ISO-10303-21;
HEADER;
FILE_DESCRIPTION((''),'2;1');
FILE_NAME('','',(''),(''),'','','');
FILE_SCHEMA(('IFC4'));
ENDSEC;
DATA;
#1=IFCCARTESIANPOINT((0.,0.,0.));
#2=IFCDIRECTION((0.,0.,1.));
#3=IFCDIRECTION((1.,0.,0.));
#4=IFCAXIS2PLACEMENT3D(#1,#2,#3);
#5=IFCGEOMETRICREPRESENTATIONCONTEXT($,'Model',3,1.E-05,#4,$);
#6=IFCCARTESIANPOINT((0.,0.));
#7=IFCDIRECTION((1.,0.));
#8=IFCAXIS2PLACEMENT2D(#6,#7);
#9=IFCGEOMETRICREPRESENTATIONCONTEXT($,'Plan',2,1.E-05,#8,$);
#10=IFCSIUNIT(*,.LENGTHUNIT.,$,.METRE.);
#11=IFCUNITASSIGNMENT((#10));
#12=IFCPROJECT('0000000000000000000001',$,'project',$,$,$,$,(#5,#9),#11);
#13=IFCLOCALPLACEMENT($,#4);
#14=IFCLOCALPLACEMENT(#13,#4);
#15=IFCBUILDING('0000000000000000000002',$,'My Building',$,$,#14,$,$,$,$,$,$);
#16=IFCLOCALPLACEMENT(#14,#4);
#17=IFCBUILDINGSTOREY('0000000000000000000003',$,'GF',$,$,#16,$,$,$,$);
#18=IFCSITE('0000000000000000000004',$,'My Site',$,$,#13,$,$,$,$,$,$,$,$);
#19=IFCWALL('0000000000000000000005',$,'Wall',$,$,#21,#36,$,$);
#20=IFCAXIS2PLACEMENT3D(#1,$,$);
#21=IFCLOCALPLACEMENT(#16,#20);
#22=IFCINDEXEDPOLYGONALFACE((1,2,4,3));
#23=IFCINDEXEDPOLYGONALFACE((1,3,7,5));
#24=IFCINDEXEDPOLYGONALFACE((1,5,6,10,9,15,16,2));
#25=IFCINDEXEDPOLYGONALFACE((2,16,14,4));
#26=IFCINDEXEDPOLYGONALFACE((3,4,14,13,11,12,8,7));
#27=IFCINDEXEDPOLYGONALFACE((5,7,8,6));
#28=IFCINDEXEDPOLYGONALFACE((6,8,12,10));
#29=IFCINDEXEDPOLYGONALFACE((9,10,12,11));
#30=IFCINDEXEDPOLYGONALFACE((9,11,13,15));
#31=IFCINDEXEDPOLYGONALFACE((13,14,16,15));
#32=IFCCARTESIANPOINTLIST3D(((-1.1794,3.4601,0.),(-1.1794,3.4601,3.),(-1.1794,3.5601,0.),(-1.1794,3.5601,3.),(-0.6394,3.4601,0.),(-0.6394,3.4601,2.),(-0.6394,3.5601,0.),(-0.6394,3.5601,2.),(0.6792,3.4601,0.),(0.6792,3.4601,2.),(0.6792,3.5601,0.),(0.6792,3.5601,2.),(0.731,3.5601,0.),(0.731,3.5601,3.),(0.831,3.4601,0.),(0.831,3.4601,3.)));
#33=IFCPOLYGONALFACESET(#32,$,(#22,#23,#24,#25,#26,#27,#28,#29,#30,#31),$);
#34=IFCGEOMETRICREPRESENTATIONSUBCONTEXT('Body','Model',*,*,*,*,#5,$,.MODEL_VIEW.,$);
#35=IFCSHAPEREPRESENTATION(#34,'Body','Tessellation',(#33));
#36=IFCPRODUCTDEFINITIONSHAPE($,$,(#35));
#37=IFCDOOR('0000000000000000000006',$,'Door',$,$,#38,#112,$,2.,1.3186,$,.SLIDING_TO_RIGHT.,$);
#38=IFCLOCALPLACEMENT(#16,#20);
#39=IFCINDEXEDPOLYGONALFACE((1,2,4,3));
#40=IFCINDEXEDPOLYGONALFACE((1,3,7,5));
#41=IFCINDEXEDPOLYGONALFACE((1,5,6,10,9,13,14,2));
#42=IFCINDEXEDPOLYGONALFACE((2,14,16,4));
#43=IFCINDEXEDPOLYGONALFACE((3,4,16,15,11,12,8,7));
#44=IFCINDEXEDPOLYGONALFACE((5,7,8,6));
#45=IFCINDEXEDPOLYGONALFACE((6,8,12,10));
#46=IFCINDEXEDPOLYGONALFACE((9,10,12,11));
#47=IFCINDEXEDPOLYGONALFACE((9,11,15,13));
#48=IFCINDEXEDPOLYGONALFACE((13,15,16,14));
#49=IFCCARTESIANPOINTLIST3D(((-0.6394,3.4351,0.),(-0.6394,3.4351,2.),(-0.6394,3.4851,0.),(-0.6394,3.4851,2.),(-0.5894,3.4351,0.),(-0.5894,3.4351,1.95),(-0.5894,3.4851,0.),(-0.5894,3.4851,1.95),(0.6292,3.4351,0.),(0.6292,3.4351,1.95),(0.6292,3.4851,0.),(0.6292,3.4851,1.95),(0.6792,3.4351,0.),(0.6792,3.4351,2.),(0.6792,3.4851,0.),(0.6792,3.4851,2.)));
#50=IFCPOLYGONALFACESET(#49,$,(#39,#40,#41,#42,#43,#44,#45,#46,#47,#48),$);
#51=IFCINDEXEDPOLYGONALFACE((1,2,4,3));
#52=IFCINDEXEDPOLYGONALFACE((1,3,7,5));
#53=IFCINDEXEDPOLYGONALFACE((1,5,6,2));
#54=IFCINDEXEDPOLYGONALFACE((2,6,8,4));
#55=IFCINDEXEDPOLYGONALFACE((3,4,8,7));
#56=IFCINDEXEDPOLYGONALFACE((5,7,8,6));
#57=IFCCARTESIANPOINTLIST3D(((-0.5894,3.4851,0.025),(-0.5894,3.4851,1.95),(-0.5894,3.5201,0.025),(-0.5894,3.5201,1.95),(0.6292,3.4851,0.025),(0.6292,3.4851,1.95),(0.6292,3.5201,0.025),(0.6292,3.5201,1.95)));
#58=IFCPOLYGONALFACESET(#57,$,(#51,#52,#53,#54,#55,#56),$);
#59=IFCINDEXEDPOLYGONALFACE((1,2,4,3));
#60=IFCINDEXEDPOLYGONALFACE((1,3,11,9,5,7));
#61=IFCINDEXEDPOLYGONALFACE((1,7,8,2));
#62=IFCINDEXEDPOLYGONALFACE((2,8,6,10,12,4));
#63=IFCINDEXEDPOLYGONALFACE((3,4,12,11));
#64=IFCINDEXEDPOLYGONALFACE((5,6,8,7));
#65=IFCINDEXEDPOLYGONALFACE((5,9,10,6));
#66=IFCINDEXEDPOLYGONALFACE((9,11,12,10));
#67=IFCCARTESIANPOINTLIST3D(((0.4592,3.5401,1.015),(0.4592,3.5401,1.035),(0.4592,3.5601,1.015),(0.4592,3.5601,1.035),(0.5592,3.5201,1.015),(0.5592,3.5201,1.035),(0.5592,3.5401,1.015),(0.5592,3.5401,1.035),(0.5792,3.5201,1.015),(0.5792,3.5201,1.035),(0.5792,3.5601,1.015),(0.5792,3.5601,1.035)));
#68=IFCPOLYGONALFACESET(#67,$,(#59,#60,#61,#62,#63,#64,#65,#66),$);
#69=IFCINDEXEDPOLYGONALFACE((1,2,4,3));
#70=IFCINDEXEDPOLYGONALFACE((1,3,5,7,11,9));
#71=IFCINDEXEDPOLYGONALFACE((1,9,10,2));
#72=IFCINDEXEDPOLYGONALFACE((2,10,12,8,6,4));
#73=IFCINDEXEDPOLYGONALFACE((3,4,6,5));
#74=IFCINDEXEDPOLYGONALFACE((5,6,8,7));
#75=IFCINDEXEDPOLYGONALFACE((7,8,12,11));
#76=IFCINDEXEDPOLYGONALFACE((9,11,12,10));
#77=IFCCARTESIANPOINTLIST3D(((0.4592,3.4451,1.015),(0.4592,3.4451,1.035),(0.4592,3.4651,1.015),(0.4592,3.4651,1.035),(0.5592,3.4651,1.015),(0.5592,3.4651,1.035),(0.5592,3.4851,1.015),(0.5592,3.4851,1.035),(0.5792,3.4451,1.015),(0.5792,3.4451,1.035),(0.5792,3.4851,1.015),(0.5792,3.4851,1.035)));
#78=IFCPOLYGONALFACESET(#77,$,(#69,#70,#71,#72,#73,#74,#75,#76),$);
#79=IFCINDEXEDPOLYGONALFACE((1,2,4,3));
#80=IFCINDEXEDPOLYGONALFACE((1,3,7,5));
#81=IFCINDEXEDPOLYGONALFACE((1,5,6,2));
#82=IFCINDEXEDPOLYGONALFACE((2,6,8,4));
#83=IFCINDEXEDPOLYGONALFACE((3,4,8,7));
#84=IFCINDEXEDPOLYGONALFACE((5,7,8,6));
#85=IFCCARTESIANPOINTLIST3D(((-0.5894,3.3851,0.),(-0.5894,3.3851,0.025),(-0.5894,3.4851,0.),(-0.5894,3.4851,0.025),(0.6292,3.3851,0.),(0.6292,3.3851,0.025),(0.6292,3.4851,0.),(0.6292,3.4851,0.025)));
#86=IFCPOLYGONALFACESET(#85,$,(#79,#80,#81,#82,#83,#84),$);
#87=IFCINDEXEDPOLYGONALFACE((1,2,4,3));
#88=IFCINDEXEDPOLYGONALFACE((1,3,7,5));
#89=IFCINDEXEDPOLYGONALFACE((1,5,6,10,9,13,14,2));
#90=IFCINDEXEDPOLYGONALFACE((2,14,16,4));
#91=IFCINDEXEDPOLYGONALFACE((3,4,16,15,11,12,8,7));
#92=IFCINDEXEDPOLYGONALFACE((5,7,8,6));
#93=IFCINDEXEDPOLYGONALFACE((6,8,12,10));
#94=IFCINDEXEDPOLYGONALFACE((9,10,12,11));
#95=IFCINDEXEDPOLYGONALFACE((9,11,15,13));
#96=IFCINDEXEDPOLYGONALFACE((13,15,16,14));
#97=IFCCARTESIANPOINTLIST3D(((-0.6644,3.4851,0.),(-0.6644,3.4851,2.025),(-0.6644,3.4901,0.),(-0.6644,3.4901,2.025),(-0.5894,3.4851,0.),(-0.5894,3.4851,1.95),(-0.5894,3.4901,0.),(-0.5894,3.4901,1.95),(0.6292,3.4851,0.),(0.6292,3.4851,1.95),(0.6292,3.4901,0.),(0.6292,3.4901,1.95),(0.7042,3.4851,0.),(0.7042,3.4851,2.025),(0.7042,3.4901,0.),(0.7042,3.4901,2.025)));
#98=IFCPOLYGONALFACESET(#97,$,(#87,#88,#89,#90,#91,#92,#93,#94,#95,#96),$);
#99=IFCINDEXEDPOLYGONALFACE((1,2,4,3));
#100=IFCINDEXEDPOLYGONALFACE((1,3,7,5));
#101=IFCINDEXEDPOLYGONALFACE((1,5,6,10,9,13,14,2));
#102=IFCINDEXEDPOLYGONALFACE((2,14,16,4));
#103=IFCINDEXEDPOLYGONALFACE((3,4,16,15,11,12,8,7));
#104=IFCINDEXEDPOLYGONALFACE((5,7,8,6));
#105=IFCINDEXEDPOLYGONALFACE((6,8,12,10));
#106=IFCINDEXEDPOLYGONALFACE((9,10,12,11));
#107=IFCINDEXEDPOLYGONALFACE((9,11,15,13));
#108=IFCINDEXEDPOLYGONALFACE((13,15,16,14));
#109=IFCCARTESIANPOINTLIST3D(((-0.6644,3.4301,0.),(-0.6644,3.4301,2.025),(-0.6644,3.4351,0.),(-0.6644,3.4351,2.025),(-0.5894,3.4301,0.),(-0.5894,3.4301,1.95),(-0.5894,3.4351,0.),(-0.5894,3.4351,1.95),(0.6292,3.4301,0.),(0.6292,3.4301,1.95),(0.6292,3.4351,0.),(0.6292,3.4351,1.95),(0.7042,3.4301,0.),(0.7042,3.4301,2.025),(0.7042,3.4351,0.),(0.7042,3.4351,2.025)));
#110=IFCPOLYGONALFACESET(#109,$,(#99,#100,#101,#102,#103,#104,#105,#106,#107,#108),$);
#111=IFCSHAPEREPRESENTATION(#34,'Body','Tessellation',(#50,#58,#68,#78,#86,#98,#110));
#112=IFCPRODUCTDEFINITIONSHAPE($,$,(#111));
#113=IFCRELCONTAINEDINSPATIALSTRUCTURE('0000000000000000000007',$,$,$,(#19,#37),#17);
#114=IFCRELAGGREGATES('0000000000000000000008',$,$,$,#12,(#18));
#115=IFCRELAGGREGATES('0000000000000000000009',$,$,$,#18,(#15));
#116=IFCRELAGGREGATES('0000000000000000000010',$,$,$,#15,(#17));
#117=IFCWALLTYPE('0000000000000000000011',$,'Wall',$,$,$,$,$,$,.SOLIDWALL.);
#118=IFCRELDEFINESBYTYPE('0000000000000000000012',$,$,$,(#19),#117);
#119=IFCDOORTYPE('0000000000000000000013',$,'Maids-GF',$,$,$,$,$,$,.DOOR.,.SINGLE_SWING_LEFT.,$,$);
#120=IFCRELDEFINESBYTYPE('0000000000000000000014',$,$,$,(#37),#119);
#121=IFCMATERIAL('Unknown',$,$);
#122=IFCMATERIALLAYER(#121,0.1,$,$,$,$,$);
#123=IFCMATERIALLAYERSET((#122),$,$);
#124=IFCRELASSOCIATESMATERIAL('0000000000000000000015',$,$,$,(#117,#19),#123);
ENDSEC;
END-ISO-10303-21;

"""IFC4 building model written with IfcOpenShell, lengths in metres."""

from ifc_helpers import new_model, entity, si_unit, frame, origin_with_axes, origin_2d_with_axis, place, context, subcontext, project, spatial, line, indexed_curve, outline, extrude, shape, source, transform, mapped, material, layer, layer_set, layer_usage, type_object, type_shapes, element, fill, save


model = new_model("IFC4")

# Units and contexts
model_context = context("Model", 3, precision=1e-05, world=origin_with_axes())
plan_context = context("Plan", 2, precision=1e-05, world=origin_2d_with_axis())
body_context_1 = subcontext(model_context, "Body", "Model", "MODEL_VIEW")
body_context_2 = subcontext(plan_context, "Body", "Plan", "PLAN_VIEW")
ifc_project = project(units=[si_unit("LENGTHUNIT", "METRE")], contexts=[model_context, plan_context])

# Site, building, storey
site_placement = place(None, origin_with_axes())
site = spatial("IfcSite", under=ifc_project, at=site_placement, Name="My Site")
building_placement = place(site_placement, origin_with_axes())
building = spatial("IfcBuilding", under=site, at=building_placement, Name="My Building")
storey_placement = place(building_placement, origin_with_axes())
storey = spatial("IfcBuildingStorey", under=building, at=storey_placement, Name="GF")

# Shared definitions
ifc_material_1 = material(Name="Unknown")

# Shared definitions
ifc_layer_1 = layer(ifc_material_1, 0.1)
ifc_layer_set_1 = layer_set([ifc_layer_1])
wall_type = type_object("IfcWallType", Name="Wall", PredefinedType="SOLIDWALL", material=ifc_layer_set_1)

# Wall, opening, door
ifc_layer_usage_1 = layer_usage(ifc_layer_set_1, "AXIS2", "POSITIVE", 0.0)
wall_1_placement = place(storey_placement, frame((0.731, 3.5601, 0.0), z_axis=(0.0, 0.0, 1.0), x_axis=(-1.0, 0.0, 0.0)))
wall_1 = element("IfcWall", 1, at=wall_1_placement, inside=storey, type_object=wall_type, material=ifc_layer_usage_1, Name="Wall", context=body_context_1, shape_type="SweptSolid", body=[
    extrude(outline(indexed_curve([(0.0, 0.0), (-0.1, 0.1), (1.9104, 0.1), (1.9104, 0.0)], segments=[line(1, 2, 3, 4, 1)])), origin_with_axes(), (0.0, 0.0, 1.0), 3.0),
])
shared_shape_1 = source(origin_with_axes(), body_context_1, "Body", "SweptSolid", [
    extrude(outline(indexed_curve([(0.0, 0.0), (1.3186, 0.0), (1.3186, 2.0), (0.0, 2.0)], segments=[line(1, 2, 3, 4, 1)])), frame((0.0, -0.6, 0.0), z_axis=(0.0, -1.0, 0.0), x_axis=(1.0, 0.0, 0.0)), (0.0, 0.0, -1.0), 1.2),
])
opening_1_placement = place(wall_1_placement, frame((0.0518, 0.075, 0.0), z_axis=(0.0, 0.0, 1.0), x_axis=(1.0, 0.0, 0.0)))
opening_1 = element("IfcOpeningElement", 2, at=opening_1_placement, cuts=wall_1, PredefinedType="OPENING", context=body_context_1, shape_type="MappedRepresentation", body=[
    mapped(shared_shape_1, transform((0.0, 0.0, 0.0), x_axis=(1.0, 0.0, 0.0), y_axis=(0.0, 1.0, 0.0), z_axis=(0.0, 0.0, 1.0), scale=1.0)),
])
door_type_1 = type_object("IfcDoorType", Name="Maids-GF", OperationType="SINGLE_SWING_LEFT", PredefinedType="DOOR")
shared_shape_2 = source(origin_with_axes(), body_context_1, "Body", "SweptSolid", [
    extrude(outline(indexed_curve([(0.0, 0.0), (0.0, 2.0), (1.3186, 2.0), (1.3186, 0.0), (1.2686, 0.0), (1.2686, 1.95), (0.05, 1.95), (0.05, 0.0)], segments=[line(1, 2, 3, 4, 5, 6, 7, 8, 1)])), frame((0.0, 0.0, 0.0), z_axis=(0.0, -1.0, 0.0), x_axis=(1.0, 0.0, 0.0)), (0.0, 0.0, -1.0), 0.05),
    extrude(outline(indexed_curve([(0.0, 0.0), (1.2186, 0.0), (1.2186, 0.035), (0.0, 0.035)], segments=[line(1, 2, 3, 4, 1)])), frame((0.05, -0.035, 0.025), z_axis=(0.0, 0.0, 1.0), x_axis=(1.0, 0.0, 0.0)), (0.0, 0.0, 1.0), 1.925),
    extrude(outline(indexed_curve([(0.0, 0.0), (0.0, -0.04), (0.12, -0.04), (0.12, -0.02), (0.02, -0.02), (0.02, 0.0)], segments=[line(1, 2, 3, 4, 5, 6, 1)])), frame((0.1, -0.035, 1.015), z_axis=(0.0, 0.0, 1.0), x_axis=(1.0, 0.0, 0.0)), (0.0, 0.0, 1.0), 0.02),
    extrude(outline(indexed_curve([(0.0, 0.0), (0.0, 0.04), (0.12, 0.04), (0.12, 0.02), (0.02, 0.02), (0.02, 0.0)], segments=[line(1, 2, 3, 4, 5, 6, 1)])), frame((0.1, 0.0, 1.015), z_axis=(0.0, 0.0, 1.0), x_axis=(1.0, 0.0, 0.0)), (0.0, 0.0, 1.0), 0.02),
    extrude(outline(indexed_curve([(0.0, 0.0), (1.2186, 0.0), (1.2186, 0.1), (0.0, 0.1)], segments=[line(1, 2, 3, 4, 1)])), frame((0.05, 0.0, 0.0), z_axis=(0.0, 0.0, 1.0), x_axis=(1.0, 0.0, 0.0)), (0.0, 0.0, 1.0), 0.025),
    extrude(outline(indexed_curve([(0.0, 0.0), (0.0, 2.025), (1.3686, 2.025), (1.3686, 0.0), (1.2936, 0.0), (1.2936, 1.95), (0.075, 1.95), (0.075, 0.0)], segments=[line(1, 2, 3, 4, 5, 6, 7, 8, 1)])), frame((-0.025, -0.005, 0.0), z_axis=(0.0, -1.0, 0.0), x_axis=(1.0, 0.0, 0.0)), (0.0, 0.0, -1.0), 0.005),
    extrude(outline(indexed_curve([(0.0, 0.0), (0.0, 2.025), (1.3686, 2.025), (1.3686, 0.0), (1.2936, 0.0), (1.2936, 1.95), (0.075, 1.95), (0.075, 0.0)], segments=[line(1, 2, 3, 4, 5, 6, 7, 8, 1)])), frame((-0.025, 0.05, 0.0), z_axis=(0.0, -1.0, 0.0), x_axis=(1.0, 0.0, 0.0)), (0.0, 0.0, -1.0), 0.005),
])
shared_shape_3 = source(origin_with_axes(), body_context_2, "Body", "Curve2D", [
    entity("IfcIndexedPolyCurve", entity("IfcCartesianPointList2D", [[0.0, 0.0], [0.05, 0.0], [0.05, 0.05], [0.0, 0.05]]), [entity("IfcLineIndex", [1, 2, 3, 4, 1])]),
    entity("IfcIndexedPolyCurve", entity("IfcCartesianPointList2D", [[1.3186, 0.0], [1.2686, 0.0], [1.2686, 0.05], [1.3186, 0.05]]), [entity("IfcLineIndex", [1, 2, 3, 4, 1])]),
    entity("IfcIndexedPolyCurve", entity("IfcCartesianPointList2D", [[1.8779, -0.035], [0.6593, -0.035], [0.6593, 0.0], [1.8779, 0.0]]), [entity("IfcLineIndex", [1, 2, 3, 4, 1])]),
])
type_shapes(door_type_1, [shared_shape_2, shared_shape_3])
door_1_placement = place(opening_1_placement, frame((0.0, 0.0, 0.0), z_axis=(0.0, 0.0, 1.0), x_axis=(1.0, 0.0, 0.0)))
door_1 = element("IfcDoor", 3, at=door_1_placement, inside=storey, type_object=door_type_1, Name="Door", OperationType="SLIDING_TO_RIGHT", OverallHeight=2.0, OverallWidth=1.3186, shapes=[
    shape(body_context_1, "Body", "MappedRepresentation", [mapped(shared_shape_2, transform((0.0, 0.0, 0.0), x_axis=(1.0, 0.0, 0.0), y_axis=(0.0, 1.0, 0.0), z_axis=(0.0, 0.0, 1.0), scale=1.0))]),
    shape(body_context_2, "Body", "MappedRepresentation", [mapped(shared_shape_3, transform((0.0, 0.0, 0.0), x_axis=(1.0, 0.0, 0.0), y_axis=(0.0, 1.0, 0.0), z_axis=(0.0, 0.0, 1.0), scale=1.0))]),
])
fill(opening_1, door_1)

save(model, "model.ifc")
